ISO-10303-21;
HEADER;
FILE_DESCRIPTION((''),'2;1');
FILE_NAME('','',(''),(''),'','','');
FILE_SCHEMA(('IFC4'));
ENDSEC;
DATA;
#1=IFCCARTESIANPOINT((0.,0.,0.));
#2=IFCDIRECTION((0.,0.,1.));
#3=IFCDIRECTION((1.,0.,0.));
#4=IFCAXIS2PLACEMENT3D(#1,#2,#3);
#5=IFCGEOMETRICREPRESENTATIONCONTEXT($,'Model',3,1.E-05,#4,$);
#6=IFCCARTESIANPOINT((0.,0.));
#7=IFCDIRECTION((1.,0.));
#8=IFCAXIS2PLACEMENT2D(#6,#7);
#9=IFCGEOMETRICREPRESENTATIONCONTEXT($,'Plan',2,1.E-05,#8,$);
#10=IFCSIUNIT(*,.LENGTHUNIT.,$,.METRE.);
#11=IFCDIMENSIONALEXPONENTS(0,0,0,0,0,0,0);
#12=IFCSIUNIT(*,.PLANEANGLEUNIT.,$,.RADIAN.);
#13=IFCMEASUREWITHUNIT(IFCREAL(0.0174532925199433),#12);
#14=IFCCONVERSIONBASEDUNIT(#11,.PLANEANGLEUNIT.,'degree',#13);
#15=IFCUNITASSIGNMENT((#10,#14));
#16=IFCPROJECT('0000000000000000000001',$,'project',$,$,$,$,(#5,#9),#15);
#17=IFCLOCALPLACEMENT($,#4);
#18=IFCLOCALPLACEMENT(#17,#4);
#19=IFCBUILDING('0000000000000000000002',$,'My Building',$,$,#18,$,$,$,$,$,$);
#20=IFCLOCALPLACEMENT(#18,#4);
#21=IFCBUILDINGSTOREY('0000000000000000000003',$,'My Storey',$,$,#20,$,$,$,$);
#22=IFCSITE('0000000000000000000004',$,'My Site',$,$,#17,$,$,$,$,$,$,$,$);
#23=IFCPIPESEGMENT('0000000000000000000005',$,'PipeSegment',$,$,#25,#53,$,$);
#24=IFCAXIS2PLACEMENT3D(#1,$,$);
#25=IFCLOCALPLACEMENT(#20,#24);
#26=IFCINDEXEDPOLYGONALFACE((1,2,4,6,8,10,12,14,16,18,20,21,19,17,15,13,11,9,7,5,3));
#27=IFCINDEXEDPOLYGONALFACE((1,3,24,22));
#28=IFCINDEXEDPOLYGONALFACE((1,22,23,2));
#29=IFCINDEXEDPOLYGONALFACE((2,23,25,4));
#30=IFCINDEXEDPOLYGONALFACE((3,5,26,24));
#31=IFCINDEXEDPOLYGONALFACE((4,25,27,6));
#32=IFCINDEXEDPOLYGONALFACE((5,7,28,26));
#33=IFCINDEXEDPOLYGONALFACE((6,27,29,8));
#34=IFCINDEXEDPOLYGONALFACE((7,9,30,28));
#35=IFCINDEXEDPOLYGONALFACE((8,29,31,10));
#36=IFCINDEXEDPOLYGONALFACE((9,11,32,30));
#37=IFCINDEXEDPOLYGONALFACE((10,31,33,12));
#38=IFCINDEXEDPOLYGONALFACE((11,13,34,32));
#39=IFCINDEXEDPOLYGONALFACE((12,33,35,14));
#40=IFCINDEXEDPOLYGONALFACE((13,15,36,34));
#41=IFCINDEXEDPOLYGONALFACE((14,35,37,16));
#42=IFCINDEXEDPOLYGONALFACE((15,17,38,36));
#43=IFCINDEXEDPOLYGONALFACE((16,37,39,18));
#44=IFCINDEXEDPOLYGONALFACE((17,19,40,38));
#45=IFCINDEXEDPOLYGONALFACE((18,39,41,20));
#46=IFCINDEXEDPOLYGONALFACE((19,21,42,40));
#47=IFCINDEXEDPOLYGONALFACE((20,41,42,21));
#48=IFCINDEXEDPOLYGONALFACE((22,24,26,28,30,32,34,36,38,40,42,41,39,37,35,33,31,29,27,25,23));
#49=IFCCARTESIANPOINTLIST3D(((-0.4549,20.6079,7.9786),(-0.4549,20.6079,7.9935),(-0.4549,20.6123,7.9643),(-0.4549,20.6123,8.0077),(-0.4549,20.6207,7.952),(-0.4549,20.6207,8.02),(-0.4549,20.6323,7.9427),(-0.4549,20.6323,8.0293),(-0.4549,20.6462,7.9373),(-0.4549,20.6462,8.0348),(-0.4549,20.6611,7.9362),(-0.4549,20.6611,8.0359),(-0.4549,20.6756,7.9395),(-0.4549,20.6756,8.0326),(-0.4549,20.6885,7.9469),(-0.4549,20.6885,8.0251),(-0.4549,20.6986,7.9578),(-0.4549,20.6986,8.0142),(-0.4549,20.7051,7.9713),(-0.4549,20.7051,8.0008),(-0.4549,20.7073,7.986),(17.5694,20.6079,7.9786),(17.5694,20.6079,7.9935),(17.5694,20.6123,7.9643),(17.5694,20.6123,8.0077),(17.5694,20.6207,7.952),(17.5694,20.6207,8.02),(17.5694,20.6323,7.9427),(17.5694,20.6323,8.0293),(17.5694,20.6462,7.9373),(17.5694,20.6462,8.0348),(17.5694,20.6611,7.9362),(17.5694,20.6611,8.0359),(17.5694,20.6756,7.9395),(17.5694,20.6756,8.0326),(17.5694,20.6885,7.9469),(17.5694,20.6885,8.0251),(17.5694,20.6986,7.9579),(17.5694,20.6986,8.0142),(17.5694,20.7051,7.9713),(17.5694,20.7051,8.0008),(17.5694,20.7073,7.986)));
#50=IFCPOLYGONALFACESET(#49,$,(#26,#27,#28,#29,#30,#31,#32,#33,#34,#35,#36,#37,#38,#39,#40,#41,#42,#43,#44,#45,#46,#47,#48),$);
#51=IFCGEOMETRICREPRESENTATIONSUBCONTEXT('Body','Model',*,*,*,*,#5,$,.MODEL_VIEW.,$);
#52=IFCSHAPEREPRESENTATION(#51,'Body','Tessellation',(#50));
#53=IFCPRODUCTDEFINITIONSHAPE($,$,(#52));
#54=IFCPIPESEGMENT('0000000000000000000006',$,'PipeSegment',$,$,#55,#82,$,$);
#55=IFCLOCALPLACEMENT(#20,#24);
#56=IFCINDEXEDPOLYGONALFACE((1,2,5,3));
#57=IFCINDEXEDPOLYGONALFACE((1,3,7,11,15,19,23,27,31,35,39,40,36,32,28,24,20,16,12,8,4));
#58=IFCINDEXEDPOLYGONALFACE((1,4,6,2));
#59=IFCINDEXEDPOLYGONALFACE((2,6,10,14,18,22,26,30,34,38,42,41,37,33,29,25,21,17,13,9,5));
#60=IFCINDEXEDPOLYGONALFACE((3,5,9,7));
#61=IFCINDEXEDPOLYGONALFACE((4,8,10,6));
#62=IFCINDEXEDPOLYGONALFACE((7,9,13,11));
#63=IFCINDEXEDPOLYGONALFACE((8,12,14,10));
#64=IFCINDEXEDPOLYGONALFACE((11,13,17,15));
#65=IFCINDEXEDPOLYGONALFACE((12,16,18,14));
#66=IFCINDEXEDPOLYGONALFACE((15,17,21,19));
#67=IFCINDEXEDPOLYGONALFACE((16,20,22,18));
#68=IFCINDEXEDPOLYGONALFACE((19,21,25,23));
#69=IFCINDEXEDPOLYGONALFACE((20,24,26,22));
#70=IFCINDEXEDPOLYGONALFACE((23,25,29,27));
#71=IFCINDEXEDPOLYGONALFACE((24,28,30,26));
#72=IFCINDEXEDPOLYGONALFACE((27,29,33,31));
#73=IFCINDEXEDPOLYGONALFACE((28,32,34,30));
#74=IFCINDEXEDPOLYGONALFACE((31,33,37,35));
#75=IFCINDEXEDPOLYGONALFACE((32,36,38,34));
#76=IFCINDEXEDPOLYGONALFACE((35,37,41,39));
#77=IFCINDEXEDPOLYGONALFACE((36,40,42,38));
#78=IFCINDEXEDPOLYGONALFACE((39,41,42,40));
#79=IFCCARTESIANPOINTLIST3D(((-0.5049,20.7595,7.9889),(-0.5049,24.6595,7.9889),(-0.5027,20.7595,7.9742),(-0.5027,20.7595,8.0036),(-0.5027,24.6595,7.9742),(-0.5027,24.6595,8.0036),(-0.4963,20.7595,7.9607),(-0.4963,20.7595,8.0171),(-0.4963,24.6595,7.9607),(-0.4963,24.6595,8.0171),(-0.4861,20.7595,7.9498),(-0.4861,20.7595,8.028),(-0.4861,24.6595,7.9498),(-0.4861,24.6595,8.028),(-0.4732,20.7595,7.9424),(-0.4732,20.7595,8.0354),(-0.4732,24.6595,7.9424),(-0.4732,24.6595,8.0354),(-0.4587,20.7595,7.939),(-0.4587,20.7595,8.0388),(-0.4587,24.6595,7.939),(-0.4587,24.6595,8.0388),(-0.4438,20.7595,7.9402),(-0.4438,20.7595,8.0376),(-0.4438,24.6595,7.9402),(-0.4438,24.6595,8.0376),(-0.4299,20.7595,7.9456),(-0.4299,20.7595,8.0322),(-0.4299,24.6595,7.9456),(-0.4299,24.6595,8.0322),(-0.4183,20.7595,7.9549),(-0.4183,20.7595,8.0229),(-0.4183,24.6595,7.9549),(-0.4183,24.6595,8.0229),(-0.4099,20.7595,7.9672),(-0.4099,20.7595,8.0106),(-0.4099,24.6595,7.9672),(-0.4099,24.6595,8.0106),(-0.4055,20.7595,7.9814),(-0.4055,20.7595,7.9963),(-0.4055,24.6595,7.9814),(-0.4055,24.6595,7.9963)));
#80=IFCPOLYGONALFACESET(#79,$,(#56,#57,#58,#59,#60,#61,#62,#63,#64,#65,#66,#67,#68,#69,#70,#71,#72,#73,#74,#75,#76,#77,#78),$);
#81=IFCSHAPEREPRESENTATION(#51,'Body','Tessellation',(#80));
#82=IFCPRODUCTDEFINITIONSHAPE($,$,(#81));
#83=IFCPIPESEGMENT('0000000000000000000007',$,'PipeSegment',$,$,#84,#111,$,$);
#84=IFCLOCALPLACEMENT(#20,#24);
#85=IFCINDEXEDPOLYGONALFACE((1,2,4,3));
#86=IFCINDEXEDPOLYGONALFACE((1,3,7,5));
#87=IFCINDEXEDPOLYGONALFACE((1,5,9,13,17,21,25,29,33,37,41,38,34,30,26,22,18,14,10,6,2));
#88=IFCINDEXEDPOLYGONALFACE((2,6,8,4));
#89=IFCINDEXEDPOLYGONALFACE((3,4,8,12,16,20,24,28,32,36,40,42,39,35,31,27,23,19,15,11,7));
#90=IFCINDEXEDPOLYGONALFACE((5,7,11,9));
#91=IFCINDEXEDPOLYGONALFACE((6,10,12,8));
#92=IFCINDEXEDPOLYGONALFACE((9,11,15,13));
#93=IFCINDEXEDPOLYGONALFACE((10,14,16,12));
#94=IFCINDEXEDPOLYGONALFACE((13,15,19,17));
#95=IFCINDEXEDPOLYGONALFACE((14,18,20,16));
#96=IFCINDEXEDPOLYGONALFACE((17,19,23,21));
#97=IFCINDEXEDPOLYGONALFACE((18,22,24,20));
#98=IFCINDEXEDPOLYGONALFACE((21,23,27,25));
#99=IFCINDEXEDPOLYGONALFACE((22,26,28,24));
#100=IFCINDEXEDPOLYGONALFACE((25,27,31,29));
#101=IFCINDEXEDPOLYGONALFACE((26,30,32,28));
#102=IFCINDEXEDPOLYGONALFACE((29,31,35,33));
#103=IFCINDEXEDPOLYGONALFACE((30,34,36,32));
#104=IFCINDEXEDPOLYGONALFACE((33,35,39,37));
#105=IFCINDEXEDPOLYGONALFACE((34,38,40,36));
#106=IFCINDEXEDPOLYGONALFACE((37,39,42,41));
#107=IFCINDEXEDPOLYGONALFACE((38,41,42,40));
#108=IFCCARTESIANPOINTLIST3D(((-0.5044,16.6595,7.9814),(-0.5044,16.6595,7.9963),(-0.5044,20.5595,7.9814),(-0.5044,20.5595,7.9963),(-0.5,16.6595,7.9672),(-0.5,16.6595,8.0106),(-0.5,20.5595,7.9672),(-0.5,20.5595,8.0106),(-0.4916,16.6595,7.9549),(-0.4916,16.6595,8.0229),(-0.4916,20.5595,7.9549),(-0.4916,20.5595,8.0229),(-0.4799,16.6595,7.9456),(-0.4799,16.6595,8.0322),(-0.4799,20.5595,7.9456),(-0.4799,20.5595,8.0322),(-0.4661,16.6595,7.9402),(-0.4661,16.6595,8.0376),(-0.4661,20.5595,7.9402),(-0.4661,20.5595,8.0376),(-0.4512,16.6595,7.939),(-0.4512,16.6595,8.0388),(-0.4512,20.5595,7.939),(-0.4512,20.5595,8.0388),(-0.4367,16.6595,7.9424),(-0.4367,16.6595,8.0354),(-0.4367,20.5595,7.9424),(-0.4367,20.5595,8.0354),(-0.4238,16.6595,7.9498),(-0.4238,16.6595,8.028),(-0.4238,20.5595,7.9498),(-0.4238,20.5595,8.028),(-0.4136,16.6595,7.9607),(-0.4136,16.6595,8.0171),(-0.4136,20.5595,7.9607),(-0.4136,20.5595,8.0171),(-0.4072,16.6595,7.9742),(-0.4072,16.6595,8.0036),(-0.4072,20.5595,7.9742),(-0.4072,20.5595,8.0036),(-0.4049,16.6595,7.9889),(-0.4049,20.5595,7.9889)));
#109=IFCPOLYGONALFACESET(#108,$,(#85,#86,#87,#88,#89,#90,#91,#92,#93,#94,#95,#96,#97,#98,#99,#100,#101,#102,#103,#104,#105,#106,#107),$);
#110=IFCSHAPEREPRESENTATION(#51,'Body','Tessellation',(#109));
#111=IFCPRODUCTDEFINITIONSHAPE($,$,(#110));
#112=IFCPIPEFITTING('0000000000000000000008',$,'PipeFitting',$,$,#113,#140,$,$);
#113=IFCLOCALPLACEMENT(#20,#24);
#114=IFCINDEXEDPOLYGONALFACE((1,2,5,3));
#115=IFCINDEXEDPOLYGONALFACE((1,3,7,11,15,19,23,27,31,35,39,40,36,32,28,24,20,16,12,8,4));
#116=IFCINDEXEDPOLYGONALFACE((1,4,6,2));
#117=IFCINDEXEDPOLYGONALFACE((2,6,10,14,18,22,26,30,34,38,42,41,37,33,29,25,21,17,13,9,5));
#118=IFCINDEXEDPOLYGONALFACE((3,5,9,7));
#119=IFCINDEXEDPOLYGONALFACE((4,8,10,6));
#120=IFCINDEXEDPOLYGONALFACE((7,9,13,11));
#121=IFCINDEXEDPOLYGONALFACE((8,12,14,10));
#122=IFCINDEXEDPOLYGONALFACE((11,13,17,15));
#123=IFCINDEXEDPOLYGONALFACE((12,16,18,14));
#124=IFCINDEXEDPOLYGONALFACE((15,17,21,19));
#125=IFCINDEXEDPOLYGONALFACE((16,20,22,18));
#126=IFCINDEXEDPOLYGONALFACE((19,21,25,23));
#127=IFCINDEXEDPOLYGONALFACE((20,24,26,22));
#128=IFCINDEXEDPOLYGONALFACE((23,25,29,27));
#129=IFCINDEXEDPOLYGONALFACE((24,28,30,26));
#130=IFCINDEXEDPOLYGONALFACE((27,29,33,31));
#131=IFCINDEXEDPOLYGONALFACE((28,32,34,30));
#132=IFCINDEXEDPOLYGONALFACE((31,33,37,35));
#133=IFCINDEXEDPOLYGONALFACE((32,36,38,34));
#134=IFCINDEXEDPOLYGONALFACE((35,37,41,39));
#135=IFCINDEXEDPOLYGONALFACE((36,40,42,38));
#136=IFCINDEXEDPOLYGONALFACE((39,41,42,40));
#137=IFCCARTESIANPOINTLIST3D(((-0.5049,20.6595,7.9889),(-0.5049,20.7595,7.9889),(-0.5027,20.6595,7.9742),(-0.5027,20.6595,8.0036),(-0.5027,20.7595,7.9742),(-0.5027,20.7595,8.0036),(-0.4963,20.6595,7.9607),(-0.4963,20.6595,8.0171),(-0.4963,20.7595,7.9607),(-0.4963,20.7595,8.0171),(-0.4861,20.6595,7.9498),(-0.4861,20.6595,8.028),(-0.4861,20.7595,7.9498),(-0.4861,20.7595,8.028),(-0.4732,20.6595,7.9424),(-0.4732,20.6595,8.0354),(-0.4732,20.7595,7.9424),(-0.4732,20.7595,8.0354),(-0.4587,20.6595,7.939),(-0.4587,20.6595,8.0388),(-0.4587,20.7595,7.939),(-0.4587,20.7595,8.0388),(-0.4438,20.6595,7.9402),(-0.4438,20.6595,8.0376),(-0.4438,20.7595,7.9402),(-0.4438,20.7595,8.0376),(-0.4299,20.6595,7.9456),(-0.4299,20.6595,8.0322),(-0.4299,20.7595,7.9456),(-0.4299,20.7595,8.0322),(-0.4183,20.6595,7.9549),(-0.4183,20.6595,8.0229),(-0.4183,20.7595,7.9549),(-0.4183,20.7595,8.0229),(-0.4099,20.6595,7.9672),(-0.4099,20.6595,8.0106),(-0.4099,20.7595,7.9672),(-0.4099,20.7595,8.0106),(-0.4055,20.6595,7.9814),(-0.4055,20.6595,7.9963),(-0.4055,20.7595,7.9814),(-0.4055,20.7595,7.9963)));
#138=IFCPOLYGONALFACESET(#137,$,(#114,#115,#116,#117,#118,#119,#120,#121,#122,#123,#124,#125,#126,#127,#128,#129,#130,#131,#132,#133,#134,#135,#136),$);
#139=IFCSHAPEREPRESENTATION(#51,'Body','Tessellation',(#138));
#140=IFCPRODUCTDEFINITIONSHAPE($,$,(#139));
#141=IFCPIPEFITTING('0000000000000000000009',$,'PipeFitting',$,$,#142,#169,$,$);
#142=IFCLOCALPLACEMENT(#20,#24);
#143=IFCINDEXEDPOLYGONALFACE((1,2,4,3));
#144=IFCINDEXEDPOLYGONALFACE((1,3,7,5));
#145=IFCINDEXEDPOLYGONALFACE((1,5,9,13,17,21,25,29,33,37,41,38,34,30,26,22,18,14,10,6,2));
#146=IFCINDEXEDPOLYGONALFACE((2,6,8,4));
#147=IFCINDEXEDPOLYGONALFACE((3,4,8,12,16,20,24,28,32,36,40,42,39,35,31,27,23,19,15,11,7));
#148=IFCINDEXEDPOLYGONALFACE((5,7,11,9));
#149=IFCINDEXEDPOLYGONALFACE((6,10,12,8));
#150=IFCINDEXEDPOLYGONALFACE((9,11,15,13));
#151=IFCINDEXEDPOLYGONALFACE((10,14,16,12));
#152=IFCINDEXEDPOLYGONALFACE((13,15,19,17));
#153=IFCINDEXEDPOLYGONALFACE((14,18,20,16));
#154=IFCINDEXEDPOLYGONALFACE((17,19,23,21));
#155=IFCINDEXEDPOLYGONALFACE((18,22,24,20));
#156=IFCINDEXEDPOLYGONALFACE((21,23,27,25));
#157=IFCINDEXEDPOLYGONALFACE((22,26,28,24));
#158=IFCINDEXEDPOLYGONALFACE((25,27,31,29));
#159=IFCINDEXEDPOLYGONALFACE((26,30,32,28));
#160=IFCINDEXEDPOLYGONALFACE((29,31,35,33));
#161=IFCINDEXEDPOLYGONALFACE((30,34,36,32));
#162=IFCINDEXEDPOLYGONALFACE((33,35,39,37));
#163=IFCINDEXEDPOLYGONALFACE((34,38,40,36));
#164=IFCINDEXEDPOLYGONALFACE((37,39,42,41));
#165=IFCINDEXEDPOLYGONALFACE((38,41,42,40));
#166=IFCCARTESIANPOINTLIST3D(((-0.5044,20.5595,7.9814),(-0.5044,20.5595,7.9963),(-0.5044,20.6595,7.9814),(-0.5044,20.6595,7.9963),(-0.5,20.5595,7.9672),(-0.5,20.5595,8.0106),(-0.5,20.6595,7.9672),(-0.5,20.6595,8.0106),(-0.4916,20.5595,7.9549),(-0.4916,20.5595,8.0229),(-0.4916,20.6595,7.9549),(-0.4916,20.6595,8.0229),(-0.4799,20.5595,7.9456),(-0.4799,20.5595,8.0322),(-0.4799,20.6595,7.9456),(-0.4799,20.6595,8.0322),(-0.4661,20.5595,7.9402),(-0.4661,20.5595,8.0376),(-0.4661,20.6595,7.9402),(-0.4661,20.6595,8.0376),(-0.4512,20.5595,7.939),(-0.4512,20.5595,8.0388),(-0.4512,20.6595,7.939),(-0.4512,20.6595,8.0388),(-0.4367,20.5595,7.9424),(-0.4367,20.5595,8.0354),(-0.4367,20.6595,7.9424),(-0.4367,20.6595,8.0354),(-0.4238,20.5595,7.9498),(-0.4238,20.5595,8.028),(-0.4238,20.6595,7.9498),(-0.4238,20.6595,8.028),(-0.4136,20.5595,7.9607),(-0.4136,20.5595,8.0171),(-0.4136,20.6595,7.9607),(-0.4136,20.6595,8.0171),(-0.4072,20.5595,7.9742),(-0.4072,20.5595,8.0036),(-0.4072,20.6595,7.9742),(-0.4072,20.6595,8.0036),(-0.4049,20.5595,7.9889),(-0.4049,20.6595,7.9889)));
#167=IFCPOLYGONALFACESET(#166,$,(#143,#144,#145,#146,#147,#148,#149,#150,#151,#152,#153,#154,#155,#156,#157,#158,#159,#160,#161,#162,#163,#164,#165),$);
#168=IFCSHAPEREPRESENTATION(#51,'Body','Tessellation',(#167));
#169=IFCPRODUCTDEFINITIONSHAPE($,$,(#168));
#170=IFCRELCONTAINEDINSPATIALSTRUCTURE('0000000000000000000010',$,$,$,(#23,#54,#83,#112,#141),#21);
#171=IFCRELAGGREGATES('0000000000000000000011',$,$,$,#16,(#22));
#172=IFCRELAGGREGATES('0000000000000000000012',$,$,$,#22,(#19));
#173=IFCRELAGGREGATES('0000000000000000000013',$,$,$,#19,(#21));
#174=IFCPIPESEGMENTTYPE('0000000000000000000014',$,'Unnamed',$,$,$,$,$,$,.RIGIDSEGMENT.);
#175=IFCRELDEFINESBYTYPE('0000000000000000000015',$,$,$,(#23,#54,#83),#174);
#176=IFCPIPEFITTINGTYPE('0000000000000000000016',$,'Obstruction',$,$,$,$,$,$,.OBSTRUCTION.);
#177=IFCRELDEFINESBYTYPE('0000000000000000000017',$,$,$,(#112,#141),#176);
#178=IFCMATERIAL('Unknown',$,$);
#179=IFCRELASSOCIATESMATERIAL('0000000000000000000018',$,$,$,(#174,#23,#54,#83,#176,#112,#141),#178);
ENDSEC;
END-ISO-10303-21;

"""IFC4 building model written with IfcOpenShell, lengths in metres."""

from ifc_helpers import new_model, entity, si_unit, converted_unit, frame, origin_with_axes, origin_2d_with_axis, place, context, subcontext, project, spatial, circle, extrude, material, material_profile, profile_set, profile_usage, type_object, element, save


model = new_model("IFC4")

# Units and contexts
model_context = context("Model", 3, precision=1e-05, world=origin_with_axes())
plan_context = context("Plan", 2, precision=1e-05, world=origin_2d_with_axis())
body_context_1 = subcontext(model_context, "Body", "Model", "MODEL_VIEW")
ifc_project = project(units=[si_unit("LENGTHUNIT", "METRE"), converted_unit("PLANEANGLEUNIT", "degree", entity("IfcReal", 0.0174532925199433), si_unit("PLANEANGLEUNIT", "RADIAN"), dimensions=[0, 0, 0, 0, 0, 0, 0])], contexts=[model_context, plan_context])

# Site, building, storey
site_placement = place(None, origin_with_axes())
site = spatial("IfcSite", under=ifc_project, at=site_placement, Name="My Site")
building_placement = place(site_placement, origin_with_axes())
building = spatial("IfcBuilding", under=site, at=building_placement, Name="My Building")
storey_placement = place(building_placement, origin_with_axes())
storey = spatial("IfcBuildingStorey", under=building, at=storey_placement, Name="My Storey")

# Shared definitions
ifc_material = material(Name="Unknown")

# Pipe segments
ifc_material_profile_1 = material_profile(ifc_material, circle(Radius=0.05))
ifc_profile_set_1 = profile_set([ifc_material_profile_1])
ifc_profile_usage_1 = profile_usage(ifc_profile_set_1, cardinal=5)
pipe_segment_type = type_object("IfcPipeSegmentType", Name="Unnamed", PredefinedType="RIGIDSEGMENT", material=ifc_profile_set_1)
pipe_segment_1_placement = place(storey_placement, frame((-0.4549, 20.6573, 7.986), z_axis=(1.0, 0.0, 0.0), x_axis=(0.0, 1.0, 0.0)))
element("IfcPipeSegment", 1, at=pipe_segment_1_placement, inside=storey, type_object=pipe_segment_type, material=ifc_profile_usage_1, Name="PipeSegment", context=body_context_1, shape_type="SweptSolid", body=[
    extrude(circle(Radius=0.05), origin_with_axes(), (0.0, 0.0, 1.0), 18.0244),
])
ifc_profile_usage_2 = profile_usage(ifc_profile_set_1, cardinal=5)
pipe_segment_2_placement = place(storey_placement, frame((-0.4549, 20.7595, 7.9889), z_axis=(0.0, 1.0, 0.0), x_axis=(-1.0, 0.0, 0.0)))
element("IfcPipeSegment", 2, at=pipe_segment_2_placement, inside=storey, type_object=pipe_segment_type, material=ifc_profile_usage_2, Name="PipeSegment", context=body_context_1, shape_type="SweptSolid", body=[
    extrude(circle(Radius=0.05), origin_with_axes(), (0.0, 0.0, 1.0), 3.9),
])
ifc_profile_usage_3 = profile_usage(ifc_profile_set_1, cardinal=5)
pipe_segment_3_placement = place(storey_placement, frame((-0.4549, 20.5595, 7.9889), z_axis=(0.0, -1.0, 0.0), x_axis=(1.0, 0.0, 0.0)))
element("IfcPipeSegment", 3, at=pipe_segment_3_placement, inside=storey, type_object=pipe_segment_type, material=ifc_profile_usage_3, Name="PipeSegment", context=body_context_1, shape_type="SweptSolid", body=[
    extrude(circle(Radius=0.05), origin_with_axes(), (0.0, 0.0, 1.0), 3.9),
])

# Pipe fittings
ifc_material_profile_2 = material_profile(ifc_material, circle(Radius=0.05))
ifc_profile_set_2 = profile_set([ifc_material_profile_2])
ifc_profile_usage_4 = profile_usage(ifc_profile_set_2, cardinal=5)
pipe_fitting_type = type_object("IfcPipeFittingType", Name="Obstruction", PredefinedType="OBSTRUCTION", material=ifc_profile_set_2)
pipe_fitting_1_placement = place(storey_placement, frame((-0.4549, 20.6595, 7.9889), z_axis=(0.0, 1.0, 0.0), x_axis=(-1.0, 0.0, 0.0)))
element("IfcPipeFitting", 4, at=pipe_fitting_1_placement, inside=storey, type_object=pipe_fitting_type, material=ifc_profile_usage_4, Name="PipeFitting", context=body_context_1, shape_type="SweptSolid", body=[
    extrude(circle(Radius=0.05), origin_with_axes(), (0.0, 0.0, 1.0), 0.1),
])
ifc_profile_usage_5 = profile_usage(ifc_profile_set_2, cardinal=5)
pipe_fitting_2_placement = place(storey_placement, frame((-0.4549, 20.6595, 7.9889), z_axis=(0.0, -1.0, 0.0), x_axis=(1.0, 0.0, 0.0)))
element("IfcPipeFitting", 5, at=pipe_fitting_2_placement, inside=storey, type_object=pipe_fitting_type, material=ifc_profile_usage_5, Name="PipeFitting", context=body_context_1, shape_type="SweptSolid", body=[
    extrude(circle(Radius=0.05), origin_with_axes(), (0.0, 0.0, 1.0), 0.1),
])

save(model, "model.ifc")
